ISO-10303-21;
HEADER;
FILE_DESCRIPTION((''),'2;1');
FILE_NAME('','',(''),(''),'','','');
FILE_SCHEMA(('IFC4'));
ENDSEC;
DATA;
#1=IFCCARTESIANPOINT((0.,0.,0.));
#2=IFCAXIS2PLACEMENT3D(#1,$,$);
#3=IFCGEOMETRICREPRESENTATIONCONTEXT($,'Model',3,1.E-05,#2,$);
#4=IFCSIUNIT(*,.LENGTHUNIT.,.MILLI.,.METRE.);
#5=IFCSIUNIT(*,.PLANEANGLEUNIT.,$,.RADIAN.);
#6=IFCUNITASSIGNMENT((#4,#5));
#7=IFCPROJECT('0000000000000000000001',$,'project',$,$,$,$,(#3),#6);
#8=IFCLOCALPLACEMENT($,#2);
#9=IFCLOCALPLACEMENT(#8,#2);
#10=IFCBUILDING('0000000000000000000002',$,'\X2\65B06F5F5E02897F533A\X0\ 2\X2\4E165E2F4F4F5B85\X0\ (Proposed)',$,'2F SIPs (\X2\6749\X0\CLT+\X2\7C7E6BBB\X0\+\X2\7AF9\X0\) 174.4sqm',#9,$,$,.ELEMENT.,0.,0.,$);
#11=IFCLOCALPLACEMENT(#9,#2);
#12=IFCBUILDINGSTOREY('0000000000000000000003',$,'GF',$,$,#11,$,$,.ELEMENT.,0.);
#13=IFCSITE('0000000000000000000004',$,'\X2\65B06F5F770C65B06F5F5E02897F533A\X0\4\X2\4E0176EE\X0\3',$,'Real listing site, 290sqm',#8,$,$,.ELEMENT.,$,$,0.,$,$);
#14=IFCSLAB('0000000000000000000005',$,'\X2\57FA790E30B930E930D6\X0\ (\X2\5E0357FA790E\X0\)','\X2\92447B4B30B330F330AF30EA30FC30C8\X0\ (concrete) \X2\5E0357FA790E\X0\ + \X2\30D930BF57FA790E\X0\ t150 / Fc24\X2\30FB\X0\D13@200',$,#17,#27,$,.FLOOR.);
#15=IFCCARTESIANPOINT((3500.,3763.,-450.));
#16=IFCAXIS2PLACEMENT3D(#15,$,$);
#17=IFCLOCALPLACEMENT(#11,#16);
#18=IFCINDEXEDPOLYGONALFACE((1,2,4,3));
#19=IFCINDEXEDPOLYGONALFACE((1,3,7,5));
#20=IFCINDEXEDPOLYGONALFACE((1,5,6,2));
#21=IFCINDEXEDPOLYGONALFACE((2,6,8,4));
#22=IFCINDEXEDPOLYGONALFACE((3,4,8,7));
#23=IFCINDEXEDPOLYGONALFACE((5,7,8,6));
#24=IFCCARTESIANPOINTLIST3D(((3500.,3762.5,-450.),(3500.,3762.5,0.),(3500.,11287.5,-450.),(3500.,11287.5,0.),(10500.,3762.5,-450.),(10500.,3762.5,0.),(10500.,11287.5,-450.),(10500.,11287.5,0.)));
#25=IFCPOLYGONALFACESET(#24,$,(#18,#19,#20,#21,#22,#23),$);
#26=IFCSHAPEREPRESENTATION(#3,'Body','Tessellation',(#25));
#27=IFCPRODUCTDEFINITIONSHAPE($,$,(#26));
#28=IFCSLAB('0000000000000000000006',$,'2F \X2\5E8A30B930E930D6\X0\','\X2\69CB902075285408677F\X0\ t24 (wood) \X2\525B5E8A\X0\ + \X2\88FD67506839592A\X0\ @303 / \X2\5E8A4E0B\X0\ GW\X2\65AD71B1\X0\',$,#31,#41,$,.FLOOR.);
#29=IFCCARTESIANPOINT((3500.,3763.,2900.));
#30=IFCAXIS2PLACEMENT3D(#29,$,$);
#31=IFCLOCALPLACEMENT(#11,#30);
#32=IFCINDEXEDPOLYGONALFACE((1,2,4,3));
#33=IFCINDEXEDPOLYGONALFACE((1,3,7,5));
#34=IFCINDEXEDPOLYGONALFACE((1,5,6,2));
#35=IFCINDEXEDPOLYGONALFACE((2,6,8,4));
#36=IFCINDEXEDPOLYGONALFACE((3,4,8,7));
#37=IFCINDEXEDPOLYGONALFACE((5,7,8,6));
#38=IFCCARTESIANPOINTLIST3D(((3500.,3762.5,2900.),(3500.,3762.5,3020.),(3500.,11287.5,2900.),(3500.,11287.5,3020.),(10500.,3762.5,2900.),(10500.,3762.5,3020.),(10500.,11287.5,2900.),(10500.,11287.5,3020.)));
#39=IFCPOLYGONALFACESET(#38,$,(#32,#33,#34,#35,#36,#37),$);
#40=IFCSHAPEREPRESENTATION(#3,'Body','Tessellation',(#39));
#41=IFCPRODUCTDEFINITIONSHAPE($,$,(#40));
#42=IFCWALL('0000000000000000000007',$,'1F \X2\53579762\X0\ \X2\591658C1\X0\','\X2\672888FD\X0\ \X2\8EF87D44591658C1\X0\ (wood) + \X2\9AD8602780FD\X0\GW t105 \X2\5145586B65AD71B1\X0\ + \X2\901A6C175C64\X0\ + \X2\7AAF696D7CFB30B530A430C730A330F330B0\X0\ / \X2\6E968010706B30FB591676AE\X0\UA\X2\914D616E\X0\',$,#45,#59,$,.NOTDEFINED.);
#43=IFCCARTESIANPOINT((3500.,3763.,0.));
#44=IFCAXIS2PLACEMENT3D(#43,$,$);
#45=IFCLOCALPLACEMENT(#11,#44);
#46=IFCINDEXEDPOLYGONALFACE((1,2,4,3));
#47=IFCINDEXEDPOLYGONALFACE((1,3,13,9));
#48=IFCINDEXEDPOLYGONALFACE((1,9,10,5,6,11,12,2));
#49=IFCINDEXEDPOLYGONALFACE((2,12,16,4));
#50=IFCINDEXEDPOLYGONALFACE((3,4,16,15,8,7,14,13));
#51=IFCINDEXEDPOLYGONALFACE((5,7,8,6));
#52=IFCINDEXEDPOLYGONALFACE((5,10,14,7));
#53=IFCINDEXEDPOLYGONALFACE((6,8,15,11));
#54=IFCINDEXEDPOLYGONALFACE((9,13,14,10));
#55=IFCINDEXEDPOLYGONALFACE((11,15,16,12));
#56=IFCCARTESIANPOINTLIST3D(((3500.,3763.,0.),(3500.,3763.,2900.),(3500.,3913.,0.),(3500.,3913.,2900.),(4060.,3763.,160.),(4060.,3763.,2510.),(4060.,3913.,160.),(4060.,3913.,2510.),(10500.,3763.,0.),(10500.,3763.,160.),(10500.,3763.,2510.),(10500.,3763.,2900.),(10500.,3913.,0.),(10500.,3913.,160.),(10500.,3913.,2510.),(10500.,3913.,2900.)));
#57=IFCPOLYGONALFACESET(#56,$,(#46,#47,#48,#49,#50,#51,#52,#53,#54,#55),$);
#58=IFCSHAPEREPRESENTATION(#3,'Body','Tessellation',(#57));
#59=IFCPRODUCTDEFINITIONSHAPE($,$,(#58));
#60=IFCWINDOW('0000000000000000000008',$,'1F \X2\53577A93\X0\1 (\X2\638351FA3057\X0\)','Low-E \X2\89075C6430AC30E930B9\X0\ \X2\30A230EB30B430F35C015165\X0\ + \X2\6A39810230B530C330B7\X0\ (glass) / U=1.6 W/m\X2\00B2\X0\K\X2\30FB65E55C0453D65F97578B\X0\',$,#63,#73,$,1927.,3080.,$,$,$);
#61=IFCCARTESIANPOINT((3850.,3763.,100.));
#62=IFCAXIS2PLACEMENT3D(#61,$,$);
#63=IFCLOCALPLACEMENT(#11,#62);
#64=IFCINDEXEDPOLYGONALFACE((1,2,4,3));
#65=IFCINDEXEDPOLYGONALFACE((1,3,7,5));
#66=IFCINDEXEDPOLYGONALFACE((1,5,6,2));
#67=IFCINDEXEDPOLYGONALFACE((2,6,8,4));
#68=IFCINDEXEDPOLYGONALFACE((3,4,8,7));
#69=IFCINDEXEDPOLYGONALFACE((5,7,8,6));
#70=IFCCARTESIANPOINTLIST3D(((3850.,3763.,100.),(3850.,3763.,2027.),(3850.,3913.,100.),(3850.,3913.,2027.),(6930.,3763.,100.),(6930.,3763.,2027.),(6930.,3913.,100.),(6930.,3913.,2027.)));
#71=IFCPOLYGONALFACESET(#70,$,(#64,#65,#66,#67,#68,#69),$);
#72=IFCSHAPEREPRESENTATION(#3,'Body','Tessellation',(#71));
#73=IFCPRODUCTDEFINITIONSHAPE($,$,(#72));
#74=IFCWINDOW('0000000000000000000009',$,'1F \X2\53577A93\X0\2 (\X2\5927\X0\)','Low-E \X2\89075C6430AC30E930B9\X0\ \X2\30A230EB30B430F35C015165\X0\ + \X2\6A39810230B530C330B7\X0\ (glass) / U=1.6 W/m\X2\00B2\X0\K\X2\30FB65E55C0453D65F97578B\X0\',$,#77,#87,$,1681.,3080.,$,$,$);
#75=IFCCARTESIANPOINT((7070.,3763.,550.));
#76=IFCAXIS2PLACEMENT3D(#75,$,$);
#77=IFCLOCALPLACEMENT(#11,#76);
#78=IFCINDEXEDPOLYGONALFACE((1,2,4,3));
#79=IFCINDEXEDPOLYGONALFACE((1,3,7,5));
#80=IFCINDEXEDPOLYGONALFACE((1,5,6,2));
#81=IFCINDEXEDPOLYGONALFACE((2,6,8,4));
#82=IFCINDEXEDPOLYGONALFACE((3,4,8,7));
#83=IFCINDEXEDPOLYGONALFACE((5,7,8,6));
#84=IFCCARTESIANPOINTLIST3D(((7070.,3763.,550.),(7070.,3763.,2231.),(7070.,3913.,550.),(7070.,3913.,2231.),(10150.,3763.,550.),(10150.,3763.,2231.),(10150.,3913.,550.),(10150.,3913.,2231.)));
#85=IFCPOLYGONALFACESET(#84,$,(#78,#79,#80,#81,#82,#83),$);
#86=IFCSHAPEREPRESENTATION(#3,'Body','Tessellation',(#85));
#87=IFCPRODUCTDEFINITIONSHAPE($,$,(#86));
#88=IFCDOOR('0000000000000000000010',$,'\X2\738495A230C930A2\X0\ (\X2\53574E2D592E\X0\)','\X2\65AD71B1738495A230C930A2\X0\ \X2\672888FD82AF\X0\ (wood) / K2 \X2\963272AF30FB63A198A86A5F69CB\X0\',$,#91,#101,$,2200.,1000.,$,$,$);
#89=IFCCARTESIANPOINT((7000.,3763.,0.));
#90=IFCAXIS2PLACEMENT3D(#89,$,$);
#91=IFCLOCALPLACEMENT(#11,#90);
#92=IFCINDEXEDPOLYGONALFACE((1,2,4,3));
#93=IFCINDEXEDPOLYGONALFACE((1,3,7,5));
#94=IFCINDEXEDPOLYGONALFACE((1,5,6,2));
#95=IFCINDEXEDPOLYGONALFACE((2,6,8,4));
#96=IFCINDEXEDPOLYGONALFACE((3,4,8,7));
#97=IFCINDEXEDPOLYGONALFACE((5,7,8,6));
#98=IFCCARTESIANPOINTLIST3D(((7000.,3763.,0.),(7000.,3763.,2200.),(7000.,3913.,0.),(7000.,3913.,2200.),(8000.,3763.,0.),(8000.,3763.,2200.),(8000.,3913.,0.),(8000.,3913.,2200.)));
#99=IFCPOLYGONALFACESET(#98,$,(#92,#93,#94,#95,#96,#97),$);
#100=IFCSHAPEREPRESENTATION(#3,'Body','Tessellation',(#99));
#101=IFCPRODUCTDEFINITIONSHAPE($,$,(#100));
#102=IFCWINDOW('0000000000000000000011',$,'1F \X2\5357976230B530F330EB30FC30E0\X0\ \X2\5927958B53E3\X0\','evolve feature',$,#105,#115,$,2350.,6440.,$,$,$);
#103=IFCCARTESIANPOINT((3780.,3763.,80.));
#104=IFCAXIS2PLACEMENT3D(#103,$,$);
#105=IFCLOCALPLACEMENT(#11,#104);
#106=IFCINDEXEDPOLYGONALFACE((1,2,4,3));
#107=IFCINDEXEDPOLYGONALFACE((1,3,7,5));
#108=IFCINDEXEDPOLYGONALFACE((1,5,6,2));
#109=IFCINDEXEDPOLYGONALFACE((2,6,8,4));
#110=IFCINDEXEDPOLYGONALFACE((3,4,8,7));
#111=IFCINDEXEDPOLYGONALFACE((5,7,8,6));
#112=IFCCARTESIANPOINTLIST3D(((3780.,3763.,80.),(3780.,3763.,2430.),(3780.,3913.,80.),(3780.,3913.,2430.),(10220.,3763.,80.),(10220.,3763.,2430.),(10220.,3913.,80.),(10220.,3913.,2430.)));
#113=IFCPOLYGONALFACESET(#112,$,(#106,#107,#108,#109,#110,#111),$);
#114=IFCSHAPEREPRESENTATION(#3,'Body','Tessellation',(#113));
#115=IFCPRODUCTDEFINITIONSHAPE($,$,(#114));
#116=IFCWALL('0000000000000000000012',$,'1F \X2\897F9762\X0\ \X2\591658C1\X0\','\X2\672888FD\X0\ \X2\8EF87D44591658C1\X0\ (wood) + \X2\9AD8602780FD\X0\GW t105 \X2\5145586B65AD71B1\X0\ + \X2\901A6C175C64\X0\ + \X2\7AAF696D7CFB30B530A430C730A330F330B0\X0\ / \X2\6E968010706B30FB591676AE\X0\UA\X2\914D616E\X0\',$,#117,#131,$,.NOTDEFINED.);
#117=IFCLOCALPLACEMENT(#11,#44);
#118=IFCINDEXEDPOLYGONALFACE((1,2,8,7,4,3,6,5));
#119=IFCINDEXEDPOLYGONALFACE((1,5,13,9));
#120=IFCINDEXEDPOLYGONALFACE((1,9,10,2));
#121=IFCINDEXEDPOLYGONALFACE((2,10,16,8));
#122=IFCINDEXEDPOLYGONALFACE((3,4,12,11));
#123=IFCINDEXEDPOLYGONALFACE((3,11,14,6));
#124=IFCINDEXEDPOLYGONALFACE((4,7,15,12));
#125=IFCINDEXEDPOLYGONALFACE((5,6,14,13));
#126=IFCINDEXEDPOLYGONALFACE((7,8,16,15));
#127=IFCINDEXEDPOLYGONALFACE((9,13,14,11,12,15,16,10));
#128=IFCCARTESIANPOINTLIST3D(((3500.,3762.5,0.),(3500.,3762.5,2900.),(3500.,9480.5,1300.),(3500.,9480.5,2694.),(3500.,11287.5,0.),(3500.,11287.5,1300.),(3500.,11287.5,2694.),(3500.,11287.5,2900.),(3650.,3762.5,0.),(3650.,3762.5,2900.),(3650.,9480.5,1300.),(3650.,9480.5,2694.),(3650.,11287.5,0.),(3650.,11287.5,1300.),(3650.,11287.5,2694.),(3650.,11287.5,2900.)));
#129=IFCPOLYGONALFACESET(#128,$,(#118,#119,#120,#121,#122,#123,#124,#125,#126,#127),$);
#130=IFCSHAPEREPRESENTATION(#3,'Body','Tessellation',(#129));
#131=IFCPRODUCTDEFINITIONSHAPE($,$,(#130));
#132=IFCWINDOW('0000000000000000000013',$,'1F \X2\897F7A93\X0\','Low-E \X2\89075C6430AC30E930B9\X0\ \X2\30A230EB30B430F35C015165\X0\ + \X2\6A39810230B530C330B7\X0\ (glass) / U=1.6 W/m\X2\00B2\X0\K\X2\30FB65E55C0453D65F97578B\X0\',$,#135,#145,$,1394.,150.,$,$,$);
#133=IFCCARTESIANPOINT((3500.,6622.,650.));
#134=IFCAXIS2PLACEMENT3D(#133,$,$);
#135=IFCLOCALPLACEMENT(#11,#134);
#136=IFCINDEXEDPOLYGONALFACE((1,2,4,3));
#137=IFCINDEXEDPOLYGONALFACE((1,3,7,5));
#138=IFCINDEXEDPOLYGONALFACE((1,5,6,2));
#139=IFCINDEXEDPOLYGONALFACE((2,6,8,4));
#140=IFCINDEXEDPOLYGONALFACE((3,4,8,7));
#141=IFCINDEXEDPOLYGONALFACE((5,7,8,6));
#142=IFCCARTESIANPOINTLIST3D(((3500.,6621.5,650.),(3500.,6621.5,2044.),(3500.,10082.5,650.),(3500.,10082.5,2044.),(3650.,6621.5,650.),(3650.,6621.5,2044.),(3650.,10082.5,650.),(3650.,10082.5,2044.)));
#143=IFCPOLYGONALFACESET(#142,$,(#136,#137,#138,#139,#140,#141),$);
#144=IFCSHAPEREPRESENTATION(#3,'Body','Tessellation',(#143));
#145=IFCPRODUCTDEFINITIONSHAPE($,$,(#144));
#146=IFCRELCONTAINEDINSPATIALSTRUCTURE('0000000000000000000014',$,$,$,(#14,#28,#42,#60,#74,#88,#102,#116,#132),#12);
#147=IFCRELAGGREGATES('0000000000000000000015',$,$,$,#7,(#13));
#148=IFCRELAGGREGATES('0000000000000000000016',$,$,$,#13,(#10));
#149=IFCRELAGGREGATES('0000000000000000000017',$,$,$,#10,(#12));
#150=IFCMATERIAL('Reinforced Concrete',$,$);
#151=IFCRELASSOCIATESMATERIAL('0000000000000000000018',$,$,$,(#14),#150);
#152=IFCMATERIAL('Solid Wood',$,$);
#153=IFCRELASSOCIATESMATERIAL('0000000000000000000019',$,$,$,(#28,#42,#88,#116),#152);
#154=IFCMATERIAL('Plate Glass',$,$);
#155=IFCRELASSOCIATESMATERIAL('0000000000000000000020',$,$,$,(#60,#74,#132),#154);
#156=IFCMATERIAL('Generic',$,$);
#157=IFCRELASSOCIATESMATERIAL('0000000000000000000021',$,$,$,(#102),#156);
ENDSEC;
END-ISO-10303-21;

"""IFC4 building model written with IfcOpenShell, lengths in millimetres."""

from ifc_helpers import new_model, si_unit, frame, frame_2d, origin, place, context, project, spatial, rectangle, extrude, material, element, fill, save


model = new_model("IFC4")

# Units and contexts
model_context = context("Model", 3, precision=1e-05, world=origin())
ifc_project = project(units=[si_unit("LENGTHUNIT", "METRE", prefix="MILLI"), si_unit("PLANEANGLEUNIT", "RADIAN")], contexts=[model_context])

# Site, building, storey
site_placement = place(None, origin())
site = spatial("IfcSite", under=ifc_project, at=site_placement, Name="新潟県新潟市西区4丁目3", ObjectType="Real listing site, 290sqm", CompositionType="ELEMENT", RefElevation=0.0)
building_placement = place(site_placement, origin())
building = spatial("IfcBuilding", under=site, at=building_placement, Name="新潟市西区 2世帯住宅 (Proposed)", ObjectType="2F SIPs (杉CLT+籾殻+竹) 174.4sqm", CompositionType="ELEMENT", ElevationOfRefHeight=0.0, ElevationOfTerrain=0.0)
storey_placement = place(building_placement, origin())
storey = spatial("IfcBuildingStorey", under=building, at=storey_placement, Name="GF", CompositionType="ELEMENT", Elevation=0.0)

# Slabs
ifc_material_1 = material(Name="Reinforced Concrete")
slab_1_placement = place(storey_placement, frame((3500.0, 3763.0, -450.0)))
element("IfcSlab", 1, at=slab_1_placement, inside=storey, material=ifc_material_1, Name="基礎スラブ (布基礎)", Description="鉄筋コンクリート (concrete) 布基礎 + ベタ基礎 t150 / Fc24・D13@200", PredefinedType="FLOOR", context=model_context, shape_type="SweptSolid", body=[
    extrude(rectangle(XDim=7000.0, YDim=7525.0, at=frame_2d((3500.0, 3762.0))), frame((3500.0, 3763.0, -450.0)), (0.0, 0.0, 1.0), 450.0),
])
ifc_material_2 = material(Name="Solid Wood")
slab_2_placement = place(storey_placement, frame((3500.0, 3763.0, 2900.0)))
element("IfcSlab", 2, at=slab_2_placement, inside=storey, material=ifc_material_2, Name="2F 床スラブ", Description="構造用合板 t24 (wood) 剛床 + 製材根太 @303 / 床下 GW断熱", PredefinedType="FLOOR", context=model_context, shape_type="SweptSolid", body=[
    extrude(rectangle(XDim=7000.0, YDim=7525.0, at=frame_2d((3500.0, 3762.0))), frame((3500.0, 3763.0, 2900.0)), (0.0, 0.0, 1.0), 120.0),
])
ifc_material_3 = material(Name="Generic")

# Wall, openings, windows, door
wall_1_placement = place(storey_placement, frame((3500.0, 3763.0, 0.0)))
wall_1 = element("IfcWall", 3, at=wall_1_placement, inside=storey, material=ifc_material_2, Name="1F 南面 外壁", Description="木製 軸組外壁 (wood) + 高性能GW t105 充填断熱 + 通気層 + 窯業系サイディング / 準耐火・外皮UA配慮", PredefinedType="NOTDEFINED", context=model_context, shape_type="SweptSolid", body=[
    extrude(rectangle(XDim=7000.0, YDim=150.0, at=frame_2d((3500.0, 75.0))), frame((3500.0, 3763.0, 0.0)), (0.0, 0.0, 1.0), 2900.0),
])
opening_1_placement = place(storey_placement, frame((3850.0, 3763.0, 100.0)))
opening_1 = element("IfcOpeningElement", 4, at=opening_1_placement, cuts=wall_1, PredefinedType="NOTDEFINED", context=model_context, shape_type="SweptSolid", body=[
    extrude(rectangle(XDim=3080.0, YDim=150.0, at=frame_2d((1540.0, 75.0))), frame((3850.0, 3763.0, 100.0)), (0.0, 0.0, 1.0), 1927.0),
])
opening_2_placement = place(storey_placement, frame((7070.0, 3763.0, 550.0)))
opening_2 = element("IfcOpeningElement", 5, at=opening_2_placement, cuts=wall_1, PredefinedType="NOTDEFINED", context=model_context, shape_type="SweptSolid", body=[
    extrude(rectangle(XDim=3080.0, YDim=150.0, at=frame_2d((1540.0, 75.0))), frame((7070.0, 3763.0, 550.0)), (0.0, 0.0, 1.0), 1681.0),
])
opening_3_placement = place(storey_placement, frame((7000.0, 3763.0, 0.0)))
opening_3 = element("IfcOpeningElement", 6, at=opening_3_placement, cuts=wall_1, PredefinedType="NOTDEFINED", context=model_context, shape_type="SweptSolid", body=[
    extrude(rectangle(XDim=1000.0, YDim=150.0, at=frame_2d((500.0, 75.0))), frame((7000.0, 3763.0, 0.0)), (0.0, 0.0, 1.0), 2200.0),
])
opening_4_placement = place(storey_placement, frame((3780.0, 3763.0, 80.0)))
opening_4 = element("IfcOpeningElement", 7, at=opening_4_placement, cuts=wall_1, PredefinedType="NOTDEFINED", context=model_context, shape_type="SweptSolid", body=[
    extrude(rectangle(XDim=6440.0, YDim=150.0, at=frame_2d((3220.0, 75.0))), frame((3780.0, 3763.0, 80.0)), (0.0, 0.0, 1.0), 2350.0),
])
ifc_material_4 = material(Name="Plate Glass")
window_1_placement = place(storey_placement, frame((3850.0, 3763.0, 100.0)))
window_1 = element("IfcWindow", 8, at=window_1_placement, inside=storey, material=ifc_material_4, Name="1F 南窓1 (掃出し)", Description="Low-E 複層ガラス アルゴン封入 + 樹脂サッシ (glass) / U=1.6 W/m²K・日射取得型", OverallHeight=1927.0, OverallWidth=3080.0, context=model_context, shape_type="SweptSolid", body=[
    extrude(rectangle(XDim=3080.0, YDim=150.0, at=frame_2d((1540.0, 75.0))), frame((3850.0, 3763.0, 100.0)), (0.0, 0.0, 1.0), 1927.0),
])
fill(opening_1, window_1)
window_2_placement = place(storey_placement, frame((7070.0, 3763.0, 550.0)))
window_2 = element("IfcWindow", 9, at=window_2_placement, inside=storey, material=ifc_material_4, Name="1F 南窓2 (大)", Description="Low-E 複層ガラス アルゴン封入 + 樹脂サッシ (glass) / U=1.6 W/m²K・日射取得型", OverallHeight=1681.0, OverallWidth=3080.0, context=model_context, shape_type="SweptSolid", body=[
    extrude(rectangle(XDim=3080.0, YDim=150.0, at=frame_2d((1540.0, 75.0))), frame((7070.0, 3763.0, 550.0)), (0.0, 0.0, 1.0), 1681.0),
])
fill(opening_2, window_2)
door_placement = place(storey_placement, frame((7000.0, 3763.0, 0.0)))
door = element("IfcDoor", 10, at=door_placement, inside=storey, material=ifc_material_2, Name="玄関ドア (南中央)", Description="断熱玄関ドア 木製芯 (wood) / K2 防犯・採風機構", OverallHeight=2200.0, OverallWidth=1000.0, context=model_context, shape_type="SweptSolid", body=[
    extrude(rectangle(XDim=1000.0, YDim=150.0, at=frame_2d((500.0, 75.0))), frame((7000.0, 3763.0, 0.0)), (0.0, 0.0, 1.0), 2200.0),
])
fill(opening_3, door)
window_3_placement = place(storey_placement, frame((3780.0, 3763.0, 80.0)))
window_3 = element("IfcWindow", 11, at=window_3_placement, inside=storey, material=ifc_material_3, Name="1F 南面サンルーム 大開口", Description="evolve feature", OverallHeight=2350.0, OverallWidth=6440.0, context=model_context, shape_type="SweptSolid", body=[
    extrude(rectangle(XDim=6440.0, YDim=150.0, at=frame_2d((3220.0, 75.0))), frame((3780.0, 3763.0, 80.0)), (0.0, 0.0, 1.0), 2350.0),
])
fill(opening_4, window_3)

# Wall, opening, window
wall_2_placement = place(storey_placement, frame((3500.0, 3763.0, 0.0)))
wall_2 = element("IfcWall", 12, at=wall_2_placement, inside=storey, material=ifc_material_2, Name="1F 西面 外壁", Description="木製 軸組外壁 (wood) + 高性能GW t105 充填断熱 + 通気層 + 窯業系サイディング / 準耐火・外皮UA配慮", PredefinedType="NOTDEFINED", context=model_context, shape_type="SweptSolid", body=[
    extrude(rectangle(XDim=150.0, YDim=7525.0, at=frame_2d((75.0, 3762.0))), frame((3500.0, 3763.0, 0.0)), (0.0, 0.0, 1.0), 2900.0),
])
opening_5_placement = place(storey_placement, frame((3500.0, 6622.0, 650.0)))
opening_5 = element("IfcOpeningElement", 13, at=opening_5_placement, cuts=wall_2, PredefinedType="NOTDEFINED", context=model_context, shape_type="SweptSolid", body=[
    extrude(rectangle(XDim=150.0, YDim=3461.0, at=frame_2d((75.0, 1730.0))), frame((3500.0, 6622.0, 650.0)), (0.0, 0.0, 1.0), 1394.0),
])
window_4_placement = place(storey_placement, frame((3500.0, 6622.0, 650.0)))
window_4 = element("IfcWindow", 14, at=window_4_placement, inside=storey, material=ifc_material_4, Name="1F 西窓", Description="Low-E 複層ガラス アルゴン封入 + 樹脂サッシ (glass) / U=1.6 W/m²K・日射取得型", OverallHeight=1394.0, OverallWidth=150.0, context=model_context, shape_type="SweptSolid", body=[
    extrude(rectangle(XDim=150.0, YDim=3461.0, at=frame_2d((75.0, 1730.0))), frame((3500.0, 6622.0, 650.0)), (0.0, 0.0, 1.0), 1394.0),
])
fill(opening_5, window_4)

save(model, "model.ifc")
